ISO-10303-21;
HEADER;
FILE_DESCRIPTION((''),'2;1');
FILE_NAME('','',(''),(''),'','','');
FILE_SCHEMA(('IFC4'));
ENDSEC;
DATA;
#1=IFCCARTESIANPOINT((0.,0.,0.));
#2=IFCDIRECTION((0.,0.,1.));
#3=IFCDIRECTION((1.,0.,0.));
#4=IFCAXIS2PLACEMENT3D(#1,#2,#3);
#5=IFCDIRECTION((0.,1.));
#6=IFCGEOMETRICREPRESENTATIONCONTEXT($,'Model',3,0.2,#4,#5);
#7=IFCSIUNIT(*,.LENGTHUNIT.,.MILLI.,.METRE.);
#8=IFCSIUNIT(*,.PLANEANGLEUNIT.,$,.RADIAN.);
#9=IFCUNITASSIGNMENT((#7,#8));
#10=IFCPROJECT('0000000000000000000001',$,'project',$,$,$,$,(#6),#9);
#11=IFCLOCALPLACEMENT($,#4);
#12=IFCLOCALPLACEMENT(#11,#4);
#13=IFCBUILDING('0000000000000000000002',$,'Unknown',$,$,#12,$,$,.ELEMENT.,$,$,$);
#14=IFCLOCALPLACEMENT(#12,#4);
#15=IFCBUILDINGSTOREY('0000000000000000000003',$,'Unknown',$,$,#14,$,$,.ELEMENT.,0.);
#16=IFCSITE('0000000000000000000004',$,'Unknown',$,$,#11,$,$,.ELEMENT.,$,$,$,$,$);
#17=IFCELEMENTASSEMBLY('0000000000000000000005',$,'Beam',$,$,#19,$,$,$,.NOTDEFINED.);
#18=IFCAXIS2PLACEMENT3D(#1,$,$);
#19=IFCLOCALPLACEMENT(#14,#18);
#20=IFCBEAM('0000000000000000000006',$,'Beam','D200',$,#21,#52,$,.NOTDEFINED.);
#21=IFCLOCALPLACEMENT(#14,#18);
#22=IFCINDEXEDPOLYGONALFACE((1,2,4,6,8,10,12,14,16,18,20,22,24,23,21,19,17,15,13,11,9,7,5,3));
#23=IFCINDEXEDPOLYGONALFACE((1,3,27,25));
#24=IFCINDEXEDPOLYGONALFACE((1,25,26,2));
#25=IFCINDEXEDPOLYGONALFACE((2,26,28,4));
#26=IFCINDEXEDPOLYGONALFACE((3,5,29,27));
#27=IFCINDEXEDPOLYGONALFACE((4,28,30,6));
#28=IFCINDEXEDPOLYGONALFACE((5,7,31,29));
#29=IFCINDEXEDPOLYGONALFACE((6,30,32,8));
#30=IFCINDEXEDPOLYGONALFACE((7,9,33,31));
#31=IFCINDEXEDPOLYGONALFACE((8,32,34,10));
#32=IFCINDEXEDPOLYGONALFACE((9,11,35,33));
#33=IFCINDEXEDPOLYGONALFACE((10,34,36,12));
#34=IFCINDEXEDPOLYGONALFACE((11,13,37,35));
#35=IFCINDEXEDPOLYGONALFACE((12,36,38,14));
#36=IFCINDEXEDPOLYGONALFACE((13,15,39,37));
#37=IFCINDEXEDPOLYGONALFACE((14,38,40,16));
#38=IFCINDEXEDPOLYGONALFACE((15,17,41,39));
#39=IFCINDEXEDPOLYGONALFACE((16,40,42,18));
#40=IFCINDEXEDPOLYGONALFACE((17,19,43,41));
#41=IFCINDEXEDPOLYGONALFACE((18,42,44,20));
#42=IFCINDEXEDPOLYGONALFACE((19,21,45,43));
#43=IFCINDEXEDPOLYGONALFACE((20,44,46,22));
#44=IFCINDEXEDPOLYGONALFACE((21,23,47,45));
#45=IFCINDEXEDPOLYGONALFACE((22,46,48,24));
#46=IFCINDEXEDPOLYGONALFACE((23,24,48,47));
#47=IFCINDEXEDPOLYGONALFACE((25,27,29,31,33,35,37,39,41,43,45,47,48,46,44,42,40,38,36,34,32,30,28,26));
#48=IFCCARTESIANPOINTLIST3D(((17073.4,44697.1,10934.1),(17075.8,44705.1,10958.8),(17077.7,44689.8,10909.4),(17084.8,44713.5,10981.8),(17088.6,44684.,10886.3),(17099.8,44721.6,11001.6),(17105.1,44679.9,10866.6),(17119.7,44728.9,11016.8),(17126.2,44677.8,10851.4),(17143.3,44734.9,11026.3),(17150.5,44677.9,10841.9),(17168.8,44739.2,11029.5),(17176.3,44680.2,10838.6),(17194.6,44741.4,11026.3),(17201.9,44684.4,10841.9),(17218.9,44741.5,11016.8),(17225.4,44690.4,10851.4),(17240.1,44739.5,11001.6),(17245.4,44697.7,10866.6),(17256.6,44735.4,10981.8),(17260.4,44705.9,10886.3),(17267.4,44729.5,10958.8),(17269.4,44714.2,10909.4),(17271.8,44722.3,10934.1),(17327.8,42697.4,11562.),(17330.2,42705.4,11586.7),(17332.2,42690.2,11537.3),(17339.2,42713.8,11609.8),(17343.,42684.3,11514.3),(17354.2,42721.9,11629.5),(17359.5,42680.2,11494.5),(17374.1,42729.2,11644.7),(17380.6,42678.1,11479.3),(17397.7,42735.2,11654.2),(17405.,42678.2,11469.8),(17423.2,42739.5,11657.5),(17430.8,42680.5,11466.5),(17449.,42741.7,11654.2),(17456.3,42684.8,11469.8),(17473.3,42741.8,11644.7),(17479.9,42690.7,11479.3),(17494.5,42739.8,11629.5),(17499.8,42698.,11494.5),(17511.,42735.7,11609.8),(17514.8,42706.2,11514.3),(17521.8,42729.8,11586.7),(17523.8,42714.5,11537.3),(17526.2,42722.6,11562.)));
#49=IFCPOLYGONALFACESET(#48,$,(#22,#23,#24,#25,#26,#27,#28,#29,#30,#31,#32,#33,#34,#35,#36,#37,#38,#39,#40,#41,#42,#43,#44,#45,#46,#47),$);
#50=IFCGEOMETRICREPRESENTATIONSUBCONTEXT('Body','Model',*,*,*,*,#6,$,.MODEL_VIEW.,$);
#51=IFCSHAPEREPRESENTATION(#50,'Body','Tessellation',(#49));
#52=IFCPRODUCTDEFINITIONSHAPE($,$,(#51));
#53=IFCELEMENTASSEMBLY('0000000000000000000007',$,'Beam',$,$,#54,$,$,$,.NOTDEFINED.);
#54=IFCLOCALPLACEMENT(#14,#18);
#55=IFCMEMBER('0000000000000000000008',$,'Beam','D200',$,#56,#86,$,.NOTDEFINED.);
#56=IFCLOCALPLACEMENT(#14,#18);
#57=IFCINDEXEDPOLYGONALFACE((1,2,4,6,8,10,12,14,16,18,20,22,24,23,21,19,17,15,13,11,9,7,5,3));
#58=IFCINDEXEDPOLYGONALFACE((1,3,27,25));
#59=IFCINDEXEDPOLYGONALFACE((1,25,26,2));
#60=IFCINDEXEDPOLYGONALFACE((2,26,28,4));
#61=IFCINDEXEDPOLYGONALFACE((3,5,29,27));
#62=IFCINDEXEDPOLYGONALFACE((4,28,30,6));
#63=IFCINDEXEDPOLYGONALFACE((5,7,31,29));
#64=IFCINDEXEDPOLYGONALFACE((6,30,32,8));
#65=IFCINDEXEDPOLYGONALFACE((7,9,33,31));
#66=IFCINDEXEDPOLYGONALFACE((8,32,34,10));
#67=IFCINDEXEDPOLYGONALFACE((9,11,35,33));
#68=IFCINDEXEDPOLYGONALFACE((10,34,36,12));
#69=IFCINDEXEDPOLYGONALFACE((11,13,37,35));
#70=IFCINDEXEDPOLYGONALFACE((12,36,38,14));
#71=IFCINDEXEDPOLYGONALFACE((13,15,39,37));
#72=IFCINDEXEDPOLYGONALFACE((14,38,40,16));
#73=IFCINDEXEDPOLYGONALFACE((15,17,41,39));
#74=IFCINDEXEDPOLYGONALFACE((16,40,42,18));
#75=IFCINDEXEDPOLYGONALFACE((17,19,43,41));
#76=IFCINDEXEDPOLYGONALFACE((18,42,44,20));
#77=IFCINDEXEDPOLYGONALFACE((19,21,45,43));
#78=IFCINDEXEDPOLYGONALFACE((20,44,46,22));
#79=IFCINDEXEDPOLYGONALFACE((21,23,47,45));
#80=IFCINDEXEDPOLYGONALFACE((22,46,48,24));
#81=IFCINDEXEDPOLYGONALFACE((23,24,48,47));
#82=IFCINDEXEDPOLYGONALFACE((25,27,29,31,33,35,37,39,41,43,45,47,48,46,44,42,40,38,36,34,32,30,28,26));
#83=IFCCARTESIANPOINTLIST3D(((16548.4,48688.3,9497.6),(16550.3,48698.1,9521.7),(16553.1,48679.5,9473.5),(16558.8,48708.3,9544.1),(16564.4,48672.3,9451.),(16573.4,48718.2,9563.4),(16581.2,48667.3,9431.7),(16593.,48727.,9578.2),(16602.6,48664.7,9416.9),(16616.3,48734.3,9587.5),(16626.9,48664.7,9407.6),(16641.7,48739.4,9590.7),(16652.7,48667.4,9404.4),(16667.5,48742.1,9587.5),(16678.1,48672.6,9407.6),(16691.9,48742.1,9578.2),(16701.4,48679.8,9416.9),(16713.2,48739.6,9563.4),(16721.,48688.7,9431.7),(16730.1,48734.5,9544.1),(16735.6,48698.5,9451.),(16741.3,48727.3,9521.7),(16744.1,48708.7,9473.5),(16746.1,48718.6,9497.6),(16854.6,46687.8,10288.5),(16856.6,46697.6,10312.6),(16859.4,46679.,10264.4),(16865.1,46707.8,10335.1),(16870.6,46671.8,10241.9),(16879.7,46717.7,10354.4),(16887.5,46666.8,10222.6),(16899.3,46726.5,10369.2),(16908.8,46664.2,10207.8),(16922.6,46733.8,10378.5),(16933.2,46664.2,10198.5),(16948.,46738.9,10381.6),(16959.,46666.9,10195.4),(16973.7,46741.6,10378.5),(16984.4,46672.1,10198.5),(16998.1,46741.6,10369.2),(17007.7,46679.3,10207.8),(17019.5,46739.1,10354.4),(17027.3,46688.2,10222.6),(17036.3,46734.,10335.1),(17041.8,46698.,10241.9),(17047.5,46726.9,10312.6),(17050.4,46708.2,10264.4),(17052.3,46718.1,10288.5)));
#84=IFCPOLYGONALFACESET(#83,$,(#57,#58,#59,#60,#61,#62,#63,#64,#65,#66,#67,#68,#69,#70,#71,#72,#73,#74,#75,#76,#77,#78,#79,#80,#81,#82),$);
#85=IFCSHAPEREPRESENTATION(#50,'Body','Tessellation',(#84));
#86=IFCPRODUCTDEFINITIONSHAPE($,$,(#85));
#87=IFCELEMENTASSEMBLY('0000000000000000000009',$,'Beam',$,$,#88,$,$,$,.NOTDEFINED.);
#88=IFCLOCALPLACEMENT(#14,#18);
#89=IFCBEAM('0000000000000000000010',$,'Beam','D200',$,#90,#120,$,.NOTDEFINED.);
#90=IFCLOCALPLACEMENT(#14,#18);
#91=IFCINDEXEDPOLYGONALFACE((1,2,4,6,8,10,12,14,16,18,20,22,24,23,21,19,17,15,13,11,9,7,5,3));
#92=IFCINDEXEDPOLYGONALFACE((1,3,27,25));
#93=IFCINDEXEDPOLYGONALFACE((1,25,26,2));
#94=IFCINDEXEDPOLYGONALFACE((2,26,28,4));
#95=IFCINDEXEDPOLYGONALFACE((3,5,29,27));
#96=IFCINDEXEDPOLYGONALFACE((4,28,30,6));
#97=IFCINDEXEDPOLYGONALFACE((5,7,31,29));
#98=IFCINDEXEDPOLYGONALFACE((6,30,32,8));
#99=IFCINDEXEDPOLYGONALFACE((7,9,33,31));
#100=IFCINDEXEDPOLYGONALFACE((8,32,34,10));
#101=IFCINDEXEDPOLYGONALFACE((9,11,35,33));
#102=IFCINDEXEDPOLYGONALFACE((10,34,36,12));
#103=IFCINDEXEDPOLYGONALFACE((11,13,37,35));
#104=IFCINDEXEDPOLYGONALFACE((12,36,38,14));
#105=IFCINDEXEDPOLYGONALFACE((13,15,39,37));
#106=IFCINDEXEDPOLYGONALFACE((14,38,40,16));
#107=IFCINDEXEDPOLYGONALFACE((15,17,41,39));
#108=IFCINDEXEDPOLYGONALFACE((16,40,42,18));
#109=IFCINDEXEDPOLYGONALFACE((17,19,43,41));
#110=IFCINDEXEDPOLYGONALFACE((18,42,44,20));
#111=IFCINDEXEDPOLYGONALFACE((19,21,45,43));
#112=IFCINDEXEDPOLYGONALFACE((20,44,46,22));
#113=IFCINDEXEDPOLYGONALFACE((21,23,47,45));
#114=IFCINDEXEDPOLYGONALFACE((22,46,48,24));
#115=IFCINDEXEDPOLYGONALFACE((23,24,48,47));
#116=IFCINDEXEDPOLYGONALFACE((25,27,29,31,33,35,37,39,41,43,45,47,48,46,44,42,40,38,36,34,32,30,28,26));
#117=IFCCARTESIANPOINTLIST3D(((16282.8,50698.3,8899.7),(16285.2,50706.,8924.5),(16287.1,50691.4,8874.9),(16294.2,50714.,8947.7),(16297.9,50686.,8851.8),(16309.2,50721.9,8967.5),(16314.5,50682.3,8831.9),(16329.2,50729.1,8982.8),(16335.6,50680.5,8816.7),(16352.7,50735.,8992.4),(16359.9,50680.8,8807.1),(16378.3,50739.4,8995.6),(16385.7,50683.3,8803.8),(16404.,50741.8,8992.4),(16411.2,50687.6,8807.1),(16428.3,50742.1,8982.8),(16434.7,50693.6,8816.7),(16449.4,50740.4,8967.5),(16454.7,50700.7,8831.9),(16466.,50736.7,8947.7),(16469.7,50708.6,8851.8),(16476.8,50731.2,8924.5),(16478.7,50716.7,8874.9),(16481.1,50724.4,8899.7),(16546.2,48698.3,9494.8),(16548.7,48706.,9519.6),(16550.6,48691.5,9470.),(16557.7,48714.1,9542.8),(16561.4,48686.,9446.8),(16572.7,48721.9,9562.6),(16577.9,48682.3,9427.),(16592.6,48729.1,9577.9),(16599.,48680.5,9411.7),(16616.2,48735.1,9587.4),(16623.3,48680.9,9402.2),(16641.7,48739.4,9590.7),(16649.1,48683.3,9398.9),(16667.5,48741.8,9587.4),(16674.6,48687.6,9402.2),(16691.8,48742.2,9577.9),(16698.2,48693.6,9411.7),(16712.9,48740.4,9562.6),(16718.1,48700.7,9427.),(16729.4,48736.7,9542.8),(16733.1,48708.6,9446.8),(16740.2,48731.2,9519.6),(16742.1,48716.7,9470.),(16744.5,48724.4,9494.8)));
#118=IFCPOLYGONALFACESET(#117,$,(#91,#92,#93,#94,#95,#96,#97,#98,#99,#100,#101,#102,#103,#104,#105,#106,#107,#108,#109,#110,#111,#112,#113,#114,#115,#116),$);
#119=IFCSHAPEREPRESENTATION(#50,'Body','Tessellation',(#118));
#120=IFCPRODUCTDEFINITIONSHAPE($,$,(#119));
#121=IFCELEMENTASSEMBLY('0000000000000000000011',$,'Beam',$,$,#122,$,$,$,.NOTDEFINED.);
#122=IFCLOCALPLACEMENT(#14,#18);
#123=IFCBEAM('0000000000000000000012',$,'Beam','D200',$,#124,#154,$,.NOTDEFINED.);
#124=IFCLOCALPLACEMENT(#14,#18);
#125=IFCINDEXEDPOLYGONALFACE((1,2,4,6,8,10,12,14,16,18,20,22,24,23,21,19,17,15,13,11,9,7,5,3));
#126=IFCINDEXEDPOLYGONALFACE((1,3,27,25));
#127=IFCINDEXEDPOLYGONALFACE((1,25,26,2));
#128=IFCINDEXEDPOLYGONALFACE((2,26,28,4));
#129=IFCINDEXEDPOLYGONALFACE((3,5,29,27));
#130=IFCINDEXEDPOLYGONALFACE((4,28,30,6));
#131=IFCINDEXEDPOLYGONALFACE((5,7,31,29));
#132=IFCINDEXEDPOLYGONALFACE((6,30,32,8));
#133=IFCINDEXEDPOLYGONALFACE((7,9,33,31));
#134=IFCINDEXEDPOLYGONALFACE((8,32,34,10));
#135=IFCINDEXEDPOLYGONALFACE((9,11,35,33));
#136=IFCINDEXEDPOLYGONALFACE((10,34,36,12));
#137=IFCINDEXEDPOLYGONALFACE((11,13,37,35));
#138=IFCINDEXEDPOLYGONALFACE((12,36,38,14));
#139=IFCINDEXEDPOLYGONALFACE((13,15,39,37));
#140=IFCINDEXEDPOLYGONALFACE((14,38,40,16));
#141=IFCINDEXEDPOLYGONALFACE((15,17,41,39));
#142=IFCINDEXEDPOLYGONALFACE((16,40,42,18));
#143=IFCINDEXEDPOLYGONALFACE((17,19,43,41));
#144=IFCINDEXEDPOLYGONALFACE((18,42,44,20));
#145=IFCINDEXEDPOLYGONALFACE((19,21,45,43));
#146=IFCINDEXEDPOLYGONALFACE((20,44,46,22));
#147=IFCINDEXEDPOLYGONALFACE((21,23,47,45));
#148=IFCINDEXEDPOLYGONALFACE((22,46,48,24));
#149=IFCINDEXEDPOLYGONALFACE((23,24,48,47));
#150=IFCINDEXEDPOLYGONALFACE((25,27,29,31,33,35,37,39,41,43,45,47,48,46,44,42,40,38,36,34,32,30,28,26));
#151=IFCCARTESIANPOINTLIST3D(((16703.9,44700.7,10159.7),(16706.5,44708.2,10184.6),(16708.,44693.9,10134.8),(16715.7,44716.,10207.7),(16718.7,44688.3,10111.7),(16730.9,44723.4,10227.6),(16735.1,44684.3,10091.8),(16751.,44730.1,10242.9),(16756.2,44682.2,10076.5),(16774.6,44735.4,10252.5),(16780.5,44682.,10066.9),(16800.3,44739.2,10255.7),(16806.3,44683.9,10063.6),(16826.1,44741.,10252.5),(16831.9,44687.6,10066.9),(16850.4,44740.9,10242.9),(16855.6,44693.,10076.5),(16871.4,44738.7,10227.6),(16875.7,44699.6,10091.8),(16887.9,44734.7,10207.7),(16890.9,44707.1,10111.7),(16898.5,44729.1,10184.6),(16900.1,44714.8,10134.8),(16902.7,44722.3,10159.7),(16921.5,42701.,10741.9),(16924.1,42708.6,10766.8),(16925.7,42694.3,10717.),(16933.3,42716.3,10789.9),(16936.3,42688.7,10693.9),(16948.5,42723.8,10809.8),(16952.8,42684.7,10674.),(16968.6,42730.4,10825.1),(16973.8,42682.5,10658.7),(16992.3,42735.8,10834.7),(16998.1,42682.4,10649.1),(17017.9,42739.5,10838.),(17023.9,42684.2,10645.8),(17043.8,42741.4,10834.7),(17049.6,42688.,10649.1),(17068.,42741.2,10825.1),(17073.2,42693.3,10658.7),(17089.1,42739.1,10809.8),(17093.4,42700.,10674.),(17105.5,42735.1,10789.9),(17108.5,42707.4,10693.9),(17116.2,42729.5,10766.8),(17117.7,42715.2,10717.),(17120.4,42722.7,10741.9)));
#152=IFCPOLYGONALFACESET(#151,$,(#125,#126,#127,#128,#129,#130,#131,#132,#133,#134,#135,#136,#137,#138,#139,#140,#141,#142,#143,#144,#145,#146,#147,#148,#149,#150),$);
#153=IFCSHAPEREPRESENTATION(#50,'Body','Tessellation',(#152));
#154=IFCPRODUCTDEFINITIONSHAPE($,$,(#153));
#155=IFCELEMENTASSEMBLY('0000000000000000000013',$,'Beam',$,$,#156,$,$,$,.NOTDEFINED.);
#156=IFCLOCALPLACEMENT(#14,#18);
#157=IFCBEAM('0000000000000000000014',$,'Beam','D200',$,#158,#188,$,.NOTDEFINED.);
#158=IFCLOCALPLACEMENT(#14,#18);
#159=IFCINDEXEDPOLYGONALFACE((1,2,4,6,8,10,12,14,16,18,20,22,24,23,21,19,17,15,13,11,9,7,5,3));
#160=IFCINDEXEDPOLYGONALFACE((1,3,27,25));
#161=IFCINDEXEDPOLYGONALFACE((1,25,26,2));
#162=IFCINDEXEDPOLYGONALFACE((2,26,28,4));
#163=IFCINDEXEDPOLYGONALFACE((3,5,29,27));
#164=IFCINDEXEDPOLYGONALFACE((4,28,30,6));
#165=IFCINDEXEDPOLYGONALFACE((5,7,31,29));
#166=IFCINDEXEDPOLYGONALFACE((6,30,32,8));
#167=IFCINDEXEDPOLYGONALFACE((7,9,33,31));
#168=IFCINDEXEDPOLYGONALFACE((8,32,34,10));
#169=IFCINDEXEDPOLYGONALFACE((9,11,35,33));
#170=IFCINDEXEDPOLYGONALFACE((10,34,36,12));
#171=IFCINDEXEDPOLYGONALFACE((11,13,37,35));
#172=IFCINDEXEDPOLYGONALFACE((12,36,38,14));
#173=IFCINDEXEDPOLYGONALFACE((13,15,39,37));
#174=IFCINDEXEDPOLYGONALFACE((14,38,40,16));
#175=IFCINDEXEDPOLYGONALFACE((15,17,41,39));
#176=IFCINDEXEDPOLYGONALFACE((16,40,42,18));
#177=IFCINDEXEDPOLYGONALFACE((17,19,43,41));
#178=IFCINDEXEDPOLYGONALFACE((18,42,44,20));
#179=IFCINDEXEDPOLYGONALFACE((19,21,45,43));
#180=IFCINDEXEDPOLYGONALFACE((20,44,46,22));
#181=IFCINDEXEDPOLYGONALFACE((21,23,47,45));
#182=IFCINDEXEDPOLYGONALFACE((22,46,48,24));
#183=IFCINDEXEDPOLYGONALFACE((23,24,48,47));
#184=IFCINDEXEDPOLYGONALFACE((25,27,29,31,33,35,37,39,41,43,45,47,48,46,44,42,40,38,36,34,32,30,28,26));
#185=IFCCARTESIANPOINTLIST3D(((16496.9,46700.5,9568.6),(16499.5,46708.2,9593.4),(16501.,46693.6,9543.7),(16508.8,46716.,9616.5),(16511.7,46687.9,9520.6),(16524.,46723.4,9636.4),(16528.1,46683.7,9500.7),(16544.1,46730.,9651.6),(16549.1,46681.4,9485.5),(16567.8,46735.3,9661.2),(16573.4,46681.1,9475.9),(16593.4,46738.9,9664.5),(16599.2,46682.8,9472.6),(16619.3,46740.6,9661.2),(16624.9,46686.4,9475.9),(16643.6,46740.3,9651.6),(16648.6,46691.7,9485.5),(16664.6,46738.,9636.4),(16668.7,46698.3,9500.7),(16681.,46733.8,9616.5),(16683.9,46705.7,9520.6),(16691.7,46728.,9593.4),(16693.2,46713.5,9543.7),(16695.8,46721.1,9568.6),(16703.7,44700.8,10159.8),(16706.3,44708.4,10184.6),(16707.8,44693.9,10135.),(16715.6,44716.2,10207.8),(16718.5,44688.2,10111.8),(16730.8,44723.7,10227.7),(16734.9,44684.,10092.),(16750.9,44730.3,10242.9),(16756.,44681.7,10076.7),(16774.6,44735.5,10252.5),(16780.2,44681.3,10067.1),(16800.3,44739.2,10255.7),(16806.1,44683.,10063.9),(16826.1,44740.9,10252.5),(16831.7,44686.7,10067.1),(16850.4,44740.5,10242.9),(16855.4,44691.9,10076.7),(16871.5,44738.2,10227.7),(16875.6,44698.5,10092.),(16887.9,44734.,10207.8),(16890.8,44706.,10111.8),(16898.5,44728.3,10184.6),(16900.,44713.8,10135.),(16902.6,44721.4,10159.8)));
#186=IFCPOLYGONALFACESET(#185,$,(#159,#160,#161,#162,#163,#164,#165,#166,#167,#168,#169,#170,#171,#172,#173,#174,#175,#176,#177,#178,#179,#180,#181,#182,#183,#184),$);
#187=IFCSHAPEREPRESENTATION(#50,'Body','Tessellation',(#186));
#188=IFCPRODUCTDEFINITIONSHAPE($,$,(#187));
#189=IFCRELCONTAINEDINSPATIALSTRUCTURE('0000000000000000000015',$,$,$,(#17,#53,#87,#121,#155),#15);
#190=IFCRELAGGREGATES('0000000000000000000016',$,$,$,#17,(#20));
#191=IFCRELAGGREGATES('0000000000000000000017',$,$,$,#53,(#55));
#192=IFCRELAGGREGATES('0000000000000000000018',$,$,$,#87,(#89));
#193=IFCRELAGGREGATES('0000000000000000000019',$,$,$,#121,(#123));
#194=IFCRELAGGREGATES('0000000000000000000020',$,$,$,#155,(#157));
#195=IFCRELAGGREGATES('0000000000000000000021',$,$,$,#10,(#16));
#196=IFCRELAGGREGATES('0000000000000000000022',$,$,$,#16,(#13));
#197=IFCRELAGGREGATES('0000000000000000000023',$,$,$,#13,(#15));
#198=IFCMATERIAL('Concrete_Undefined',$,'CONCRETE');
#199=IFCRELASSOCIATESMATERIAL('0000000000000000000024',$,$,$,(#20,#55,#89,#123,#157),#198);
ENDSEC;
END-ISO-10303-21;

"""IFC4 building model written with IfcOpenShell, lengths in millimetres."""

from ifc_helpers import new_model, si_unit, direction, frame, origin_with_axes, place, context, subcontext, project, spatial, line, indexed_curve, outline, extrude, material, element, aggregate, save


model = new_model("IFC4")

# Units and contexts
model_context = context("Model", 3, precision=0.2, world=origin_with_axes(), true_north=direction((0.0, 1.0)))
body_context = subcontext(model_context, "Body", "Model", "MODEL_VIEW")
ifc_project = project(units=[si_unit("LENGTHUNIT", "METRE", prefix="MILLI"), si_unit("PLANEANGLEUNIT", "RADIAN")], contexts=[model_context])

# Site, building, storey
site_placement = place(None, origin_with_axes())
site = spatial("IfcSite", under=ifc_project, at=site_placement, Name="Unknown", CompositionType="ELEMENT")
building_placement = place(site_placement, origin_with_axes())
building = spatial("IfcBuilding", under=site, at=building_placement, Name="Unknown", CompositionType="ELEMENT")
storey_placement = place(building_placement, origin_with_axes())
storey = spatial("IfcBuildingStorey", under=building, at=storey_placement, Name="Unknown", CompositionType="ELEMENT", Elevation=0.0)

# Shared definitions
ifc_material = material(Name="Concrete_Undefined", Category="CONCRETE")

# Element assembly, beam
assembly_1_placement = place(storey_placement, frame((17172.6, 44709.7, 10934.1), z_axis=(-0.992004, -0.126205, 0.0), x_axis=(0.120494, -0.947114, 0.297415)))
assembly_1 = element("IfcElementAssembly", 1, at=assembly_1_placement, inside=storey, Name="Beam", PredefinedType="NOTDEFINED")
beam_1_placement = place(assembly_1_placement, origin_with_axes())
beam_1 = element("IfcBeam", 2, at=beam_1_placement, material=ifc_material, Name="Beam", Description="D200", PredefinedType="NOTDEFINED", context=body_context, shape_type="SolidModel", body=[
    extrude(outline(indexed_curve([(100.0, 0.0), (96.6, 25.9), (86.6, 50.0), (70.7, 70.7), (50.0, 86.6), (25.9, 96.6), (0.0, 100.0), (-25.9, 96.6), (-50.0, 86.6), (-70.7, 70.7), (-86.6, 50.0), (-96.6, 25.9), (-100.0, 0.0), (-96.6, -25.9), (-86.6, -50.0), (-70.7, -70.7), (-50.0, -86.6), (-25.9, -96.6), (0.0, -100.0), (25.9, -96.6), (50.0, -86.6), (70.7, -70.7), (86.6, -50.0), (96.6, -25.9)], segments=[line(1, 2, 3, 4, 5, 6, 7, 8, 9, 10, 11, 12, 13, 14, 15, 16, 17, 18, 19, 20, 21, 22, 23, 24, 1)])), frame((0.0, 0.0, 0.0), z_axis=(-1.0, 0.0, 0.0), x_axis=(0.0, 0.0, 1.0)), (0.0, 0.0, -1.0), 2111.4),
])
aggregate(assembly_1, [beam_1])

# Element assembly, member
assembly_2_placement = place(storey_placement, frame((16647.2, 48703.4, 9497.6), z_axis=(-0.988482, -0.151337, 0.0), x_axis=(0.140955, -0.920671, 0.364)))
assembly_2 = element("IfcElementAssembly", 3, at=assembly_2_placement, inside=storey, Name="Beam", PredefinedType="NOTDEFINED")
member_1_placement = place(assembly_2_placement, origin_with_axes())
member_1 = element("IfcMember", 4, at=member_1_placement, material=ifc_material, Name="Beam", Description="D200", PredefinedType="NOTDEFINED", context=body_context, shape_type="SolidModel", body=[
    extrude(outline(indexed_curve([(100.0, 0.0), (96.6, 25.9), (86.6, 50.0), (70.7, 70.7), (50.0, 86.6), (25.9, 96.6), (0.0, 100.0), (-25.9, 96.6), (-50.0, 86.6), (-70.7, 70.7), (-86.6, 50.0), (-96.6, 25.9), (-100.0, 0.0), (-96.6, -25.9), (-86.6, -50.0), (-70.7, -70.7), (-50.0, -86.6), (-25.9, -96.6), (0.0, -100.0), (25.9, -96.6), (50.0, -86.6), (70.7, -70.7), (86.6, -50.0), (96.6, -25.9)], segments=[line(1, 2, 3, 4, 5, 6, 7, 8, 9, 10, 11, 12, 13, 14, 15, 16, 17, 18, 19, 20, 21, 22, 23, 24, 1)])), frame((0.0, 0.0, 0.0), z_axis=(-1.0, 0.0, 0.0), x_axis=(0.0, 0.0, 1.0)), (0.0, 0.0, -1.0), 2172.9),
])
aggregate(assembly_2, [member_1])

# Element assemblies, beams
assembly_3_placement = place(storey_placement, frame((16382.0, 50711.3, 8899.7), z_axis=(-0.991436, -0.130591, 0.0), x_axis=(0.125254, -0.950922, 0.282945)))
assembly_3 = element("IfcElementAssembly", 5, at=assembly_3_placement, inside=storey, Name="Beam", PredefinedType="NOTDEFINED")
beam_2_placement = place(assembly_3_placement, origin_with_axes())
beam_2 = element("IfcBeam", 6, at=beam_2_placement, material=ifc_material, Name="Beam", Description="D200", PredefinedType="NOTDEFINED", context=body_context, shape_type="SolidModel", body=[
    extrude(outline(indexed_curve([(100.0, 0.0), (96.6, 25.9), (86.6, 50.0), (70.7, 70.7), (50.0, 86.6), (25.9, 96.6), (0.0, 100.0), (-25.9, 96.6), (-50.0, 86.6), (-70.7, 70.7), (-86.6, 50.0), (-96.6, 25.9), (-100.0, 0.0), (-96.6, -25.9), (-86.6, -50.0), (-70.7, -70.7), (-50.0, -86.6), (-25.9, -96.6), (0.0, -100.0), (25.9, -96.6), (50.0, -86.6), (70.7, -70.7), (86.6, -50.0), (96.6, -25.9)], segments=[line(1, 2, 3, 4, 5, 6, 7, 8, 9, 10, 11, 12, 13, 14, 15, 16, 17, 18, 19, 20, 21, 22, 23, 24, 1)])), frame((0.0, 0.0, 0.0), z_axis=(-1.0, 0.0, 0.0), x_axis=(0.0, 0.0, 1.0)), (0.0, 0.0, -1.0), 2103.2),
])
aggregate(assembly_3, [beam_2])
assembly_4_placement = place(storey_placement, frame((16803.3, 44711.5, 10159.7), z_axis=(-0.994128, -0.108208, 0.0), x_axis=(0.103942, -0.954931, 0.278032)))
assembly_4 = element("IfcElementAssembly", 7, at=assembly_4_placement, inside=storey, Name="Beam", PredefinedType="NOTDEFINED")
beam_3_placement = place(assembly_4_placement, origin_with_axes())
beam_3 = element("IfcBeam", 8, at=beam_3_placement, material=ifc_material, Name="Beam", Description="D200", PredefinedType="NOTDEFINED", context=body_context, shape_type="SolidModel", body=[
    extrude(outline(indexed_curve([(100.0, 0.0), (96.6, 25.9), (86.6, 50.0), (70.7, 70.7), (50.0, 86.6), (25.9, 96.6), (0.0, 100.0), (-25.9, 96.6), (-50.0, 86.6), (-70.7, 70.7), (-86.6, 50.0), (-96.6, 25.9), (-100.0, 0.0), (-96.6, -25.9), (-86.6, -50.0), (-70.7, -70.7), (-50.0, -86.6), (-25.9, -96.6), (0.0, -100.0), (25.9, -96.6), (50.0, -86.6), (70.7, -70.7), (86.6, -50.0), (96.6, -25.9)], segments=[line(1, 2, 3, 4, 5, 6, 7, 8, 9, 10, 11, 12, 13, 14, 15, 16, 17, 18, 19, 20, 21, 22, 23, 24, 1)])), frame((0.0, 0.0, 0.0), z_axis=(-1.0, 0.0, 0.0), x_axis=(0.0, 0.0, 1.0)), (0.0, 0.0, -1.0), 2094.0),
])
aggregate(assembly_4, [beam_3])
assembly_5_placement = place(storey_placement, frame((16596.3, 46710.8, 9568.6), z_axis=(-0.994694, -0.102879, 0.0), x_axis=(0.098699, -0.954279, 0.282152)))
assembly_5 = element("IfcElementAssembly", 9, at=assembly_5_placement, inside=storey, Name="Beam", PredefinedType="NOTDEFINED")
beam_4_placement = place(assembly_5_placement, origin_with_axes())
beam_4 = element("IfcBeam", 10, at=beam_4_placement, material=ifc_material, Name="Beam", Description="D200", PredefinedType="NOTDEFINED", context=body_context, shape_type="SolidModel", body=[
    extrude(outline(indexed_curve([(100.0, 0.0), (96.6, 25.9), (86.6, 50.0), (70.7, 70.7), (50.0, 86.6), (25.9, 96.6), (0.0, 100.0), (-25.9, 96.6), (-50.0, 86.6), (-70.7, 70.7), (-86.6, 50.0), (-96.6, 25.9), (-100.0, 0.0), (-96.6, -25.9), (-86.6, -50.0), (-70.7, -70.7), (-50.0, -86.6), (-25.9, -96.6), (0.0, -100.0), (25.9, -96.6), (50.0, -86.6), (70.7, -70.7), (86.6, -50.0), (96.6, -25.9)], segments=[line(1, 2, 3, 4, 5, 6, 7, 8, 9, 10, 11, 12, 13, 14, 15, 16, 17, 18, 19, 20, 21, 22, 23, 24, 1)])), frame((0.0, 0.0, 0.0), z_axis=(-1.0, 0.0, 0.0), x_axis=(0.0, 0.0, 1.0)), (0.0, 0.0, -1.0), 2095.5),
])
aggregate(assembly_5, [beam_4])

save(model, "model.ifc")
